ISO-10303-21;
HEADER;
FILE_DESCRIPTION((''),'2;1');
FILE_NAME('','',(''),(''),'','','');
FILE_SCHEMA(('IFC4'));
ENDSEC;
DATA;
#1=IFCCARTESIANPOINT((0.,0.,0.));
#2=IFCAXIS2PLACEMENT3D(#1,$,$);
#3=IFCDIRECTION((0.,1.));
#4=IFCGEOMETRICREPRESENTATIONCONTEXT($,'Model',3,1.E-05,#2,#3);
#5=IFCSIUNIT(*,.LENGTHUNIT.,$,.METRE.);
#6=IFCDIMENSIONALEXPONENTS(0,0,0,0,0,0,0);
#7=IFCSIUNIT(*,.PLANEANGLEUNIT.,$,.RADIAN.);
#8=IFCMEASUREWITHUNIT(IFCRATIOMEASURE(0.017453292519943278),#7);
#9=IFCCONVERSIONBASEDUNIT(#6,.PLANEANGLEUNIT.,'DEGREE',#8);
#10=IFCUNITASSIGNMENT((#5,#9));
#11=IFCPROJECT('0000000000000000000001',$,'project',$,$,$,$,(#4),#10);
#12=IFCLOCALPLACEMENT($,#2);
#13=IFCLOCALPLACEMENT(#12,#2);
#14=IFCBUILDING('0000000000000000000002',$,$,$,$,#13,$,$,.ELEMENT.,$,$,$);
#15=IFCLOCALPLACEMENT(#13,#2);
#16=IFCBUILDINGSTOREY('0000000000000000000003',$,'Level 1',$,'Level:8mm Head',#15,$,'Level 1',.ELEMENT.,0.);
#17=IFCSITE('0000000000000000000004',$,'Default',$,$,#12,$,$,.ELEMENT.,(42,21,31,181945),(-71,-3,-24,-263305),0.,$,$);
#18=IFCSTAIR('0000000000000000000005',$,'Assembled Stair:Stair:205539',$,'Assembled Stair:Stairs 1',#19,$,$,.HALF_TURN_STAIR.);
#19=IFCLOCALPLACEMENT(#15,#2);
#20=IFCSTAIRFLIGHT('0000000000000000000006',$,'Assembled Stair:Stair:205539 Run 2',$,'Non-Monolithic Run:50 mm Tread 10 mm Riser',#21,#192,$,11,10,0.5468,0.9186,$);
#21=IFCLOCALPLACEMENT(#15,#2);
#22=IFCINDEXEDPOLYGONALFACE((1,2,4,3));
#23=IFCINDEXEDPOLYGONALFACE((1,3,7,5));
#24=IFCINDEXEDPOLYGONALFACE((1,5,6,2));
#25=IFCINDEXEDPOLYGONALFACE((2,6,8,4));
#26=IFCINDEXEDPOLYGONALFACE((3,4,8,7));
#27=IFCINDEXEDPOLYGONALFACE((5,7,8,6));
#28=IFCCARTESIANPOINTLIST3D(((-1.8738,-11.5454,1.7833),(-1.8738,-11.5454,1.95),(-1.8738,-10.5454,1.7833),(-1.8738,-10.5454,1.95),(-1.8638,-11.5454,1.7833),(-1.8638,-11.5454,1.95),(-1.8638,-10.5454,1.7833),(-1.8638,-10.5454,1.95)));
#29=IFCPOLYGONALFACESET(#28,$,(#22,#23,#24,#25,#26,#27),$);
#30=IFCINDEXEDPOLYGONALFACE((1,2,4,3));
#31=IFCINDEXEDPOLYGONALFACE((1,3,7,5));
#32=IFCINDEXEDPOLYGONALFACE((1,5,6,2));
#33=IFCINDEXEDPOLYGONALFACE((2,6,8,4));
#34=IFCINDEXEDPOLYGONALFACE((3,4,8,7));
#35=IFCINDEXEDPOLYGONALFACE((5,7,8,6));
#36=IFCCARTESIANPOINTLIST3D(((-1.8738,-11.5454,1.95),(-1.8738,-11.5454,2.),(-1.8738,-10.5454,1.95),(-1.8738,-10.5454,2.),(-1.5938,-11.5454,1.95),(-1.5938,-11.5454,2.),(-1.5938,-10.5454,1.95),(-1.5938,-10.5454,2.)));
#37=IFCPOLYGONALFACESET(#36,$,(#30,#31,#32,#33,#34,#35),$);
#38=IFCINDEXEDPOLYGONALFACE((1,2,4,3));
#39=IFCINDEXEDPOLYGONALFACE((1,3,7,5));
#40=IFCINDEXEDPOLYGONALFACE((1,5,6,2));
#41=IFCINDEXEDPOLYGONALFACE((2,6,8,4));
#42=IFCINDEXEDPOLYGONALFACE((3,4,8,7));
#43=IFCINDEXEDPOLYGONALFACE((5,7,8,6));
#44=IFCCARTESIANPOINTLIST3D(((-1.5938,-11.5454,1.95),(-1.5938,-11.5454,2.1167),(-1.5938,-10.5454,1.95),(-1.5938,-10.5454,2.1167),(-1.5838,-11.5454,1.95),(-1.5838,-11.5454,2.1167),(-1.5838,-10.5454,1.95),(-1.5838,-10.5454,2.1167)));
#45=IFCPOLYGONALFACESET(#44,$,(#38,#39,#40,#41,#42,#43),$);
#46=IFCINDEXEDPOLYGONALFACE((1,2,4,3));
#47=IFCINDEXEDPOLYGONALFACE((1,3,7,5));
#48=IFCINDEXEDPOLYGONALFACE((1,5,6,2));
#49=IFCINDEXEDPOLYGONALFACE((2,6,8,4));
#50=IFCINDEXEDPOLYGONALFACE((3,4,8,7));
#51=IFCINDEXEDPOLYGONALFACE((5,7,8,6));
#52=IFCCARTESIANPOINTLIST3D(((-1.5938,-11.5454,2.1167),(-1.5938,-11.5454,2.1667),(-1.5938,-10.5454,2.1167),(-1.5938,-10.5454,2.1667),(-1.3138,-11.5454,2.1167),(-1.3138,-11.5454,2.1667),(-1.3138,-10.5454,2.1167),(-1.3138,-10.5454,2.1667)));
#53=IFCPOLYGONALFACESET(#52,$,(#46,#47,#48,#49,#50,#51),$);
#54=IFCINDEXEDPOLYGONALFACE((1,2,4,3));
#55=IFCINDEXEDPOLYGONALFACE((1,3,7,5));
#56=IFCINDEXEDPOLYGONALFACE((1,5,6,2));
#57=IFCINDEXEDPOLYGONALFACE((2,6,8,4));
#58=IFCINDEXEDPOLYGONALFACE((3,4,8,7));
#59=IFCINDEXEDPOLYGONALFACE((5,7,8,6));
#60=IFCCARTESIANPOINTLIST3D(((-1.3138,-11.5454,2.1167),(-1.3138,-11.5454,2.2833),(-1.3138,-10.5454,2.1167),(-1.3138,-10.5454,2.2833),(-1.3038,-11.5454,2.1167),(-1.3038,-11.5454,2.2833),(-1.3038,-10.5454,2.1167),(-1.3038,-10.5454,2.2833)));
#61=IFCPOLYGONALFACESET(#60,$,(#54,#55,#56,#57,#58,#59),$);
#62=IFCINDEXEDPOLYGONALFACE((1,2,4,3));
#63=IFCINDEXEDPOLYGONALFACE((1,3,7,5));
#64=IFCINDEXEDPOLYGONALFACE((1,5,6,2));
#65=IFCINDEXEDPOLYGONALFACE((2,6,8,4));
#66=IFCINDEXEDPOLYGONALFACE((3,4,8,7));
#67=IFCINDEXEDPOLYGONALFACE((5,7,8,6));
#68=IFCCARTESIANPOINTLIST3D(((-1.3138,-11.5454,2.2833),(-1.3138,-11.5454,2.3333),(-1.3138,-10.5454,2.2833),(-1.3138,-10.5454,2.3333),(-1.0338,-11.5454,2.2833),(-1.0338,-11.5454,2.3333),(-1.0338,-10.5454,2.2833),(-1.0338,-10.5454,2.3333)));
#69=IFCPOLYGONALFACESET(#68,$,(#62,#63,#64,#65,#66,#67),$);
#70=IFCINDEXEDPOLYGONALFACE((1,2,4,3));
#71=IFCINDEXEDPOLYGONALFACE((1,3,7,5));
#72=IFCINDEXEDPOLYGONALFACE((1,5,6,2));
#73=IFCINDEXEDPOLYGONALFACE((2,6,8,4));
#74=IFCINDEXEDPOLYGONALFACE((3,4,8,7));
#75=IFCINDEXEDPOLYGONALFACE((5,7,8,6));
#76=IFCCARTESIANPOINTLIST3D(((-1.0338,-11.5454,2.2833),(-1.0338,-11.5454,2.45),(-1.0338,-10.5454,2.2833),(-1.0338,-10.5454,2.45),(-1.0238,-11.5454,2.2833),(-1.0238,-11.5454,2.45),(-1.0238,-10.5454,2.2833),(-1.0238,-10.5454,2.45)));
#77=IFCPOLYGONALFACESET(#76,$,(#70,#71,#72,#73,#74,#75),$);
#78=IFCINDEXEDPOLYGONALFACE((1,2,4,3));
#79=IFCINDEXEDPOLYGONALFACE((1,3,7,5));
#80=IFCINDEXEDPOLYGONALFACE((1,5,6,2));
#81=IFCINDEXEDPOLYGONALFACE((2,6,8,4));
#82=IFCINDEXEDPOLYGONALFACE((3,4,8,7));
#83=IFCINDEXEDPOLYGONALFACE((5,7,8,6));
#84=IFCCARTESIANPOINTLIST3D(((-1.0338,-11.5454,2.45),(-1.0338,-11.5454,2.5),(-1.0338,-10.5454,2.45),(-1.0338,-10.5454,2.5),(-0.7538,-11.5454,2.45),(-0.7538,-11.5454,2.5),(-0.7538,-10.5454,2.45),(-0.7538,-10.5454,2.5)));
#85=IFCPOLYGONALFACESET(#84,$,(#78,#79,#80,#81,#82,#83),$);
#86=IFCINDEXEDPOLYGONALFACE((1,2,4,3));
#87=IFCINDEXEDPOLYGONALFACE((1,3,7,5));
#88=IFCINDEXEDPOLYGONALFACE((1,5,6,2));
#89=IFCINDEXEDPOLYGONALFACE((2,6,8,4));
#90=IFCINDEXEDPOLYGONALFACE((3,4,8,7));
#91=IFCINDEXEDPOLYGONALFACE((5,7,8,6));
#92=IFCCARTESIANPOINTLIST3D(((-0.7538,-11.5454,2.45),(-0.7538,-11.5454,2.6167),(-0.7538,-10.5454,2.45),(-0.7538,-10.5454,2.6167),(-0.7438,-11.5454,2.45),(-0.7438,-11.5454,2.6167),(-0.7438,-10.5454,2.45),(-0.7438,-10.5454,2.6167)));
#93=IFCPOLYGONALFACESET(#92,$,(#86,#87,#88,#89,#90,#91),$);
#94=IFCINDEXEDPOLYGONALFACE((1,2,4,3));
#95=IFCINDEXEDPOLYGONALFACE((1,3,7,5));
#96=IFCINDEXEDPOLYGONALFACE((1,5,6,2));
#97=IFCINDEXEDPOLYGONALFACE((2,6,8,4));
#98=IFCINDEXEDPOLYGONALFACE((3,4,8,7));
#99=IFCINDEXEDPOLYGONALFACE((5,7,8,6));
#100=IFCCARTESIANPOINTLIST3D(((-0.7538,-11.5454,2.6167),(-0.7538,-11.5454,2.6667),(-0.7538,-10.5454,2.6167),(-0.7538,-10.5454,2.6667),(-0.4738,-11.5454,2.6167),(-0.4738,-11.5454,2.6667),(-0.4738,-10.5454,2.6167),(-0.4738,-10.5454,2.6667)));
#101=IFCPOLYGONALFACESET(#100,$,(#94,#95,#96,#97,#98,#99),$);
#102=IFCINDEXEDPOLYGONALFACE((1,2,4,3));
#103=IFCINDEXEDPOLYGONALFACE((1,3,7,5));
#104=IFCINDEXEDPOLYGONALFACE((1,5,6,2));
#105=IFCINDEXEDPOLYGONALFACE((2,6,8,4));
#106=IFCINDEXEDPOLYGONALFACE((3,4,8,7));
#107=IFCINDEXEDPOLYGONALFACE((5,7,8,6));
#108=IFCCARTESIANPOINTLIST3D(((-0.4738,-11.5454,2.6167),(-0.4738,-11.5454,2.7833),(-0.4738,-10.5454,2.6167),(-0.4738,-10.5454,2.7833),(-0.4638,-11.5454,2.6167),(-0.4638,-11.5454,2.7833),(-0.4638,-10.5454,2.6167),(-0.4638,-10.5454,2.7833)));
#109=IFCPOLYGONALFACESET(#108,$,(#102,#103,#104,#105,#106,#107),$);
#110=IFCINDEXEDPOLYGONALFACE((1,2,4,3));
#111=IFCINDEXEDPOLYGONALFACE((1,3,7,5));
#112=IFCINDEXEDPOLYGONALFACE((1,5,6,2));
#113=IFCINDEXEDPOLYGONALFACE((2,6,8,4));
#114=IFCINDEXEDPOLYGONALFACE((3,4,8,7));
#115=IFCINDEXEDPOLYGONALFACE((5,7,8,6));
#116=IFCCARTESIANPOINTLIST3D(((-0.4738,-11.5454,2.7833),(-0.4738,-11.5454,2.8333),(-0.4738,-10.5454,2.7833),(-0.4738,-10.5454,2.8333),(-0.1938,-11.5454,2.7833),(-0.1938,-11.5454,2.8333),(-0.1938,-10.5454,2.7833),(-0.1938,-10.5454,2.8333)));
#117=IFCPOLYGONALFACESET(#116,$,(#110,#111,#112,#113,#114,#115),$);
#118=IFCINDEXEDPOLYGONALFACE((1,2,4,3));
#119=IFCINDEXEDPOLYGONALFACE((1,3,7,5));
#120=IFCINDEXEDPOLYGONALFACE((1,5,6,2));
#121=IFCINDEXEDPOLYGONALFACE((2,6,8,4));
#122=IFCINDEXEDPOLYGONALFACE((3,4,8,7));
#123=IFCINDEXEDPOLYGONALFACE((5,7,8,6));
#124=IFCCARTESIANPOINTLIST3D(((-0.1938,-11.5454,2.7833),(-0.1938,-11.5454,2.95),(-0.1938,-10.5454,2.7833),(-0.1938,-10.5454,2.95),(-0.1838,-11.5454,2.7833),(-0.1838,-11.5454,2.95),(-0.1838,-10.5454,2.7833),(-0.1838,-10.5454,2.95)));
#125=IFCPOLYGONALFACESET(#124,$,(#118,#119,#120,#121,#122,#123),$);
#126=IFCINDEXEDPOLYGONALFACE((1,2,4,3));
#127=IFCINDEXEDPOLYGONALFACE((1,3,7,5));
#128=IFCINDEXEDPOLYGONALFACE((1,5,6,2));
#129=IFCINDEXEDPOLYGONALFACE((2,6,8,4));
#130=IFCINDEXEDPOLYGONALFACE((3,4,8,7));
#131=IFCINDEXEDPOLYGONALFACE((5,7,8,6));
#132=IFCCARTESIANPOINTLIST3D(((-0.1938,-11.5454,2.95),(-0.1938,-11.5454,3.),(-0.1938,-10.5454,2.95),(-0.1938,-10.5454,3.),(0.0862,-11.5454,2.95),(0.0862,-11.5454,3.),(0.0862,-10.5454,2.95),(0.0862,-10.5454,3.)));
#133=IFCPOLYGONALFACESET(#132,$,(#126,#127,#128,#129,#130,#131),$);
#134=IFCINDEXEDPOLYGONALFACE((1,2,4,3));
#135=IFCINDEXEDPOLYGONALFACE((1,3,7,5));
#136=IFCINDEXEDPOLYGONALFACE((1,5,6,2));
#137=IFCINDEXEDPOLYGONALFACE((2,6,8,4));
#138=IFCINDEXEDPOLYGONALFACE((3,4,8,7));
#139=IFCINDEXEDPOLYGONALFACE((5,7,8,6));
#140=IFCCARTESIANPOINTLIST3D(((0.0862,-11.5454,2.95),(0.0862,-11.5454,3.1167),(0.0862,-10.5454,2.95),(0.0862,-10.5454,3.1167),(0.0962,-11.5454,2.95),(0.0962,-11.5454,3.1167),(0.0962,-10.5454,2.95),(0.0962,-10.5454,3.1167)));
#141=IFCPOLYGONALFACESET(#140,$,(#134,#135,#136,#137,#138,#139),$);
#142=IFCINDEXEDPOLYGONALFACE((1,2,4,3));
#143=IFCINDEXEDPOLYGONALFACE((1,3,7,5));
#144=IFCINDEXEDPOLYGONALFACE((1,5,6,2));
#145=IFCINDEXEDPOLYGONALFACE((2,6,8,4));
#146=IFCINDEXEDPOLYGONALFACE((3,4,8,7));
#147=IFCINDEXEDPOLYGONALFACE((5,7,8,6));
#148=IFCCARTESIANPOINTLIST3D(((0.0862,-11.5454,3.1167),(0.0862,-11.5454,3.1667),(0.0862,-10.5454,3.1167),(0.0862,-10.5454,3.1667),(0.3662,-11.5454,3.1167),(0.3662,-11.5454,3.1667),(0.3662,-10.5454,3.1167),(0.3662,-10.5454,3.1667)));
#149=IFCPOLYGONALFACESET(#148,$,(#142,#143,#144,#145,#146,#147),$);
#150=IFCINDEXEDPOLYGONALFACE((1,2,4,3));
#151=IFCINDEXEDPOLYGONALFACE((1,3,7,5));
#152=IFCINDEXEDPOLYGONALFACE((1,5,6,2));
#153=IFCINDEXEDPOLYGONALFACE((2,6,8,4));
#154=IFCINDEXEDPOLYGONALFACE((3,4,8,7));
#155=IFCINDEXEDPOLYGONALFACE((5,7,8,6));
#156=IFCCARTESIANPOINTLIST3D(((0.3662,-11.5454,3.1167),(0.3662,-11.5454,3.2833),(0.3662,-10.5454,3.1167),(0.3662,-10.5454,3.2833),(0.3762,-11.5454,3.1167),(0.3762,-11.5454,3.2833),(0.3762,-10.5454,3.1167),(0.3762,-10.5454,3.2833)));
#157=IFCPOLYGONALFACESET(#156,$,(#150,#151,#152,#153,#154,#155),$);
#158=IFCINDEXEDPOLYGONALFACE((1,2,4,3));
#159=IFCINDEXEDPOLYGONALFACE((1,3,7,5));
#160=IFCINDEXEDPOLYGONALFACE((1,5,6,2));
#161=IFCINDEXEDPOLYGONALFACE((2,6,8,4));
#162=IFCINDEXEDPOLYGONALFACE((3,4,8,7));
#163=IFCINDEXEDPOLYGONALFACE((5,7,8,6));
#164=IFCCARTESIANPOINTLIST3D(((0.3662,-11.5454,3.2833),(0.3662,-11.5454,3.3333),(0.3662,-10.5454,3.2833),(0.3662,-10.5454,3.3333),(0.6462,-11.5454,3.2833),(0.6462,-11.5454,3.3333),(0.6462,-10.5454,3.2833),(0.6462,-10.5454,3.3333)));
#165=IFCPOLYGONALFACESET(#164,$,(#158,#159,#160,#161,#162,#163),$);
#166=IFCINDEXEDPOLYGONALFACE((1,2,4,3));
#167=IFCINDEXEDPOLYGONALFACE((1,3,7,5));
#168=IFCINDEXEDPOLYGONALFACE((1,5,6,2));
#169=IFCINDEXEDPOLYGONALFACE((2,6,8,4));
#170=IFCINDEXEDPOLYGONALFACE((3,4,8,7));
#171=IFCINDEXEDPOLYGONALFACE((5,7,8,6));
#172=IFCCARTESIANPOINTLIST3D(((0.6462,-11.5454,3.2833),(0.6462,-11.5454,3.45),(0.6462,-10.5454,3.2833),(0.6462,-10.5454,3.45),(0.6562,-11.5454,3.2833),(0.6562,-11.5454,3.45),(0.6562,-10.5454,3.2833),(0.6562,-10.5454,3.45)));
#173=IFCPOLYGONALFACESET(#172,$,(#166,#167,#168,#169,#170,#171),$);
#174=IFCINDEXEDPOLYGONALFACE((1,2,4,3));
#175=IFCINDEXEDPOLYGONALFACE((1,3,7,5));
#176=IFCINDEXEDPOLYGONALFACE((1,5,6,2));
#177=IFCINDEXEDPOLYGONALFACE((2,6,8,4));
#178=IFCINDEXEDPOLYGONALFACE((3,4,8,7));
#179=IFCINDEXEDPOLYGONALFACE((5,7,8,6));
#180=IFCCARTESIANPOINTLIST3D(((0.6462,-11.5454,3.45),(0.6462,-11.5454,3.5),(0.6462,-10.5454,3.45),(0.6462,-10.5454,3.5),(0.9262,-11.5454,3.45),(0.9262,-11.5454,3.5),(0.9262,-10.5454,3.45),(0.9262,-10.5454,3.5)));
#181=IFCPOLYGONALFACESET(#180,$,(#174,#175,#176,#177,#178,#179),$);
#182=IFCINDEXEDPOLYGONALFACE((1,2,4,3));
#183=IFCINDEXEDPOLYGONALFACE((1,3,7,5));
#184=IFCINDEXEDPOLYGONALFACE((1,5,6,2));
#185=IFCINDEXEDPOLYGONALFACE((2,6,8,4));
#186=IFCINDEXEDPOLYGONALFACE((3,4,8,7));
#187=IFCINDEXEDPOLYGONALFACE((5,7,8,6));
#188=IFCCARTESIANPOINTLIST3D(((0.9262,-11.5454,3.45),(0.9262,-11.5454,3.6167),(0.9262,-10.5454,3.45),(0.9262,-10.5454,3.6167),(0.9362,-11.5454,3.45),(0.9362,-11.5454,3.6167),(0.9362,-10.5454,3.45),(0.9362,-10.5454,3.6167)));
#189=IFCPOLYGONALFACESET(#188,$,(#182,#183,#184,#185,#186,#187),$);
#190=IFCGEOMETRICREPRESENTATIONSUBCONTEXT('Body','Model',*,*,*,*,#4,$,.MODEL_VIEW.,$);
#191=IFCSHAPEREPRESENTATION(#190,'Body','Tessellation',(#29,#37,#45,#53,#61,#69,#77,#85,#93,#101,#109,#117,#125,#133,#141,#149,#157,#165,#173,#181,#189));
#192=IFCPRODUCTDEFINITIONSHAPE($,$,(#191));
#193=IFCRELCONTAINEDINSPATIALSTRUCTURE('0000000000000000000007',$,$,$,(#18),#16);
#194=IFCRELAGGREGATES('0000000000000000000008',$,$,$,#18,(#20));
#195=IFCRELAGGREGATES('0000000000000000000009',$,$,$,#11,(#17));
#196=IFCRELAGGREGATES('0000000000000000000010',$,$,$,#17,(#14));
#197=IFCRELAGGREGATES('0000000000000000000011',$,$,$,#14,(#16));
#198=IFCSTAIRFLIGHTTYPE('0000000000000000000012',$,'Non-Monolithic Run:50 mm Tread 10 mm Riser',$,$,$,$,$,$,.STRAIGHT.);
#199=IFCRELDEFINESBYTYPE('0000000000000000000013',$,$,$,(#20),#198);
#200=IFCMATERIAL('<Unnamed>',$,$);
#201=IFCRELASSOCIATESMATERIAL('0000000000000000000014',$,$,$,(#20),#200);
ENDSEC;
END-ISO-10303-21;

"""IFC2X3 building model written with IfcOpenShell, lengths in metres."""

from ifc_helpers import new_model, entity, si_unit, converted_unit, direction, frame, frame_2d, origin, origin_2d_with_axis, place, context, subcontext, project, spatial, rectangle, extrude, material, type_object, element, aggregate, save


model = new_model("IFC2X3")

# Units and contexts
model_context = context("Model", 3, precision=1e-05, world=origin(), true_north=direction((0.0, 1.0)))
body_context = subcontext(model_context, "Body", "Model", "MODEL_VIEW")
ifc_project = project(units=[si_unit("LENGTHUNIT", "METRE"), converted_unit("PLANEANGLEUNIT", "DEGREE", entity("IfcRatioMeasure", 0.017453292519943278), si_unit("PLANEANGLEUNIT", "RADIAN"), dimensions=[0, 0, 0, 0, 0, 0, 0])], contexts=[model_context])

# Site, building, storey
site_placement = place(None, origin())
site = spatial("IfcSite", under=ifc_project, at=site_placement, Name="Default", CompositionType="ELEMENT", RefLatitude=(42, 21, 31, 181945), RefLongitude=(-71, -3, -24, -263305), RefElevation=0.0)
building_placement = place(site_placement, origin())
building = spatial("IfcBuilding", under=site, at=building_placement, CompositionType="ELEMENT")
storey_placement = place(building_placement, origin())
storey = spatial("IfcBuildingStorey", under=building, at=storey_placement, Name="Level 1", ObjectType="Level:8mm Head", LongName="Level 1", CompositionType="ELEMENT", Elevation=0.0)

# Stair
stair_placement = place(storey_placement, origin())
stair = element("IfcStair", 1, at=stair_placement, inside=storey, Name="Assembled Stair:Stair:205539", ObjectType="Assembled Stair:Stairs 1", ShapeType="HALF_TURN_STAIR")
ifc_material_1 = material(Name="<Unnamed>")

# Stair flight
stair_flight_type_1 = type_object("IfcStairFlightType", Name="Non-Monolithic Run:50 mm Tread 10 mm Riser", PredefinedType="STRAIGHT")
stair_flight_1_placement = place(stair_placement, origin())
stair_flight_1 = element("IfcStairFlight", 2, at=stair_flight_1_placement, type_object=stair_flight_type_1, material=ifc_material_1, Name="Assembled Stair:Stair:205539 Run 2", ObjectType="Non-Monolithic Run:50 mm Tread 10 mm Riser", NumberOfRiser=11, NumberOfTreads=10, RiserHeight=0.5468, TreadLength=0.9186, context=body_context, shape_type="SweptSolid", body=[
    extrude(rectangle(XDim=1.0, YDim=0.01, at=origin_2d_with_axis()), frame((-1.8688, -11.0454, 1.7833), z_axis=(0.0, 0.0, 1.0), x_axis=(0.0, 1.0, 0.0)), (0.0, 0.0, 1.0), 0.1667),
    extrude(rectangle(XDim=0.28, YDim=1.0, at=frame_2d((0.0, 0.0), x_axis=(1.0, 0.0))), frame((-1.7338, -11.0454, 1.95), z_axis=(0.0, 0.0, 1.0), x_axis=(-1.0, 0.0, 0.0)), (0.0, 0.0, 1.0), 0.05),
    extrude(rectangle(XDim=1.0, YDim=0.01, at=frame_2d((0.0, 0.0), x_axis=(1.0, 0.0))), frame((-1.5888, -11.0454, 1.95), z_axis=(0.0, 0.0, 1.0), x_axis=(0.0, 1.0, 0.0)), (0.0, 0.0, 1.0), 0.1667),
    extrude(rectangle(XDim=0.28, YDim=1.0, at=frame_2d((0.0, 0.0), x_axis=(1.0, 0.0))), frame((-1.4538, -11.0454, 2.1167), z_axis=(0.0, 0.0, 1.0), x_axis=(-1.0, 0.0, 0.0)), (0.0, 0.0, 1.0), 0.05),
    extrude(rectangle(XDim=1.0, YDim=0.01, at=frame_2d((0.0, 0.0), x_axis=(1.0, 0.0))), frame((-1.3088, -11.0454, 2.1167), z_axis=(0.0, 0.0, 1.0), x_axis=(0.0, 1.0, 0.0)), (0.0, 0.0, 1.0), 0.1667),
    extrude(rectangle(XDim=0.28, YDim=1.0, at=frame_2d((0.0, 0.0), x_axis=(1.0, 0.0))), frame((-1.1738, -11.0454, 2.2833), z_axis=(0.0, 0.0, 1.0), x_axis=(-1.0, 0.0, 0.0)), (0.0, 0.0, 1.0), 0.05),
    extrude(rectangle(XDim=1.0, YDim=0.01, at=origin_2d_with_axis()), frame((-1.0288, -11.0454, 2.2833), z_axis=(0.0, 0.0, 1.0), x_axis=(0.0, 1.0, 0.0)), (0.0, 0.0, 1.0), 0.1667),
    extrude(rectangle(XDim=0.28, YDim=1.0, at=frame_2d((0.0, 0.0), x_axis=(1.0, 0.0))), frame((-0.8938, -11.0454, 2.45), z_axis=(0.0, 0.0, 1.0), x_axis=(-1.0, 0.0, 0.0)), (0.0, 0.0, 1.0), 0.05),
    extrude(rectangle(XDim=1.0, YDim=0.01, at=origin_2d_with_axis()), frame((-0.7488, -11.0454, 2.45), z_axis=(0.0, 0.0, 1.0), x_axis=(0.0, 1.0, 0.0)), (0.0, 0.0, 1.0), 0.1667),
    extrude(rectangle(XDim=0.28, YDim=1.0, at=frame_2d((0.0, 0.0), x_axis=(1.0, 0.0))), frame((-0.6138, -11.0454, 2.6167), z_axis=(0.0, 0.0, 1.0), x_axis=(-1.0, 0.0, 0.0)), (0.0, 0.0, 1.0), 0.05),
    extrude(rectangle(XDim=1.0, YDim=0.01, at=origin_2d_with_axis()), frame((-0.4688, -11.0454, 2.6167), z_axis=(0.0, 0.0, 1.0), x_axis=(0.0, 1.0, 0.0)), (0.0, 0.0, 1.0), 0.1667),
    extrude(rectangle(XDim=0.28, YDim=1.0, at=frame_2d((0.0, 0.0), x_axis=(1.0, 0.0))), frame((-0.3338, -11.0454, 2.7833), z_axis=(0.0, 0.0, 1.0), x_axis=(-1.0, 0.0, 0.0)), (0.0, 0.0, 1.0), 0.05),
    extrude(rectangle(XDim=1.0, YDim=0.01, at=origin_2d_with_axis()), frame((-0.1888, -11.0454, 2.7833), z_axis=(0.0, 0.0, 1.0), x_axis=(0.0, 1.0, 0.0)), (0.0, 0.0, 1.0), 0.1667),
    extrude(rectangle(XDim=0.28, YDim=1.0, at=frame_2d((0.0, 0.0), x_axis=(1.0, 0.0))), frame((-0.0538, -11.0454, 2.95), z_axis=(0.0, 0.0, 1.0), x_axis=(-1.0, 0.0, 0.0)), (0.0, 0.0, 1.0), 0.05),
    extrude(rectangle(XDim=1.0, YDim=0.01, at=origin_2d_with_axis()), frame((0.0912, -11.0454, 2.95), z_axis=(0.0, 0.0, 1.0), x_axis=(0.0, 1.0, 0.0)), (0.0, 0.0, 1.0), 0.1667),
    extrude(rectangle(XDim=0.28, YDim=1.0, at=frame_2d((0.0, 0.0), x_axis=(1.0, 0.0))), frame((0.2262, -11.0454, 3.1167), z_axis=(0.0, 0.0, 1.0), x_axis=(-1.0, 0.0, 0.0)), (0.0, 0.0, 1.0), 0.05),
    extrude(rectangle(XDim=1.0, YDim=0.01, at=origin_2d_with_axis()), frame((0.3712, -11.0454, 3.1167), z_axis=(0.0, 0.0, 1.0), x_axis=(0.0, 1.0, 0.0)), (0.0, 0.0, 1.0), 0.1667),
    extrude(rectangle(XDim=0.28, YDim=1.0, at=frame_2d((0.0, 0.0), x_axis=(1.0, 0.0))), frame((0.5062, -11.0454, 3.2833), z_axis=(0.0, 0.0, 1.0), x_axis=(-1.0, 0.0, 0.0)), (0.0, 0.0, 1.0), 0.05),
    extrude(rectangle(XDim=1.0, YDim=0.01, at=origin_2d_with_axis()), frame((0.6512, -11.0454, 3.2833), z_axis=(0.0, 0.0, 1.0), x_axis=(0.0, 1.0, 0.0)), (0.0, 0.0, 1.0), 0.1667),
    extrude(rectangle(XDim=0.28, YDim=1.0, at=frame_2d((0.0, 0.0), x_axis=(1.0, 0.0))), frame((0.7862, -11.0454, 3.45), z_axis=(0.0, 0.0, 1.0), x_axis=(-1.0, 0.0, 0.0)), (0.0, 0.0, 1.0), 0.05),
    extrude(rectangle(XDim=1.0, YDim=0.01, at=frame_2d((0.0, 0.0), x_axis=(1.0, 0.0))), frame((0.9312, -11.0454, 3.45), z_axis=(0.0, 0.0, 1.0), x_axis=(0.0, 1.0, 0.0)), (0.0, 0.0, 1.0), 0.1667),
])
aggregate(stair, [stair_flight_1])

save(model, "model.ifc")
